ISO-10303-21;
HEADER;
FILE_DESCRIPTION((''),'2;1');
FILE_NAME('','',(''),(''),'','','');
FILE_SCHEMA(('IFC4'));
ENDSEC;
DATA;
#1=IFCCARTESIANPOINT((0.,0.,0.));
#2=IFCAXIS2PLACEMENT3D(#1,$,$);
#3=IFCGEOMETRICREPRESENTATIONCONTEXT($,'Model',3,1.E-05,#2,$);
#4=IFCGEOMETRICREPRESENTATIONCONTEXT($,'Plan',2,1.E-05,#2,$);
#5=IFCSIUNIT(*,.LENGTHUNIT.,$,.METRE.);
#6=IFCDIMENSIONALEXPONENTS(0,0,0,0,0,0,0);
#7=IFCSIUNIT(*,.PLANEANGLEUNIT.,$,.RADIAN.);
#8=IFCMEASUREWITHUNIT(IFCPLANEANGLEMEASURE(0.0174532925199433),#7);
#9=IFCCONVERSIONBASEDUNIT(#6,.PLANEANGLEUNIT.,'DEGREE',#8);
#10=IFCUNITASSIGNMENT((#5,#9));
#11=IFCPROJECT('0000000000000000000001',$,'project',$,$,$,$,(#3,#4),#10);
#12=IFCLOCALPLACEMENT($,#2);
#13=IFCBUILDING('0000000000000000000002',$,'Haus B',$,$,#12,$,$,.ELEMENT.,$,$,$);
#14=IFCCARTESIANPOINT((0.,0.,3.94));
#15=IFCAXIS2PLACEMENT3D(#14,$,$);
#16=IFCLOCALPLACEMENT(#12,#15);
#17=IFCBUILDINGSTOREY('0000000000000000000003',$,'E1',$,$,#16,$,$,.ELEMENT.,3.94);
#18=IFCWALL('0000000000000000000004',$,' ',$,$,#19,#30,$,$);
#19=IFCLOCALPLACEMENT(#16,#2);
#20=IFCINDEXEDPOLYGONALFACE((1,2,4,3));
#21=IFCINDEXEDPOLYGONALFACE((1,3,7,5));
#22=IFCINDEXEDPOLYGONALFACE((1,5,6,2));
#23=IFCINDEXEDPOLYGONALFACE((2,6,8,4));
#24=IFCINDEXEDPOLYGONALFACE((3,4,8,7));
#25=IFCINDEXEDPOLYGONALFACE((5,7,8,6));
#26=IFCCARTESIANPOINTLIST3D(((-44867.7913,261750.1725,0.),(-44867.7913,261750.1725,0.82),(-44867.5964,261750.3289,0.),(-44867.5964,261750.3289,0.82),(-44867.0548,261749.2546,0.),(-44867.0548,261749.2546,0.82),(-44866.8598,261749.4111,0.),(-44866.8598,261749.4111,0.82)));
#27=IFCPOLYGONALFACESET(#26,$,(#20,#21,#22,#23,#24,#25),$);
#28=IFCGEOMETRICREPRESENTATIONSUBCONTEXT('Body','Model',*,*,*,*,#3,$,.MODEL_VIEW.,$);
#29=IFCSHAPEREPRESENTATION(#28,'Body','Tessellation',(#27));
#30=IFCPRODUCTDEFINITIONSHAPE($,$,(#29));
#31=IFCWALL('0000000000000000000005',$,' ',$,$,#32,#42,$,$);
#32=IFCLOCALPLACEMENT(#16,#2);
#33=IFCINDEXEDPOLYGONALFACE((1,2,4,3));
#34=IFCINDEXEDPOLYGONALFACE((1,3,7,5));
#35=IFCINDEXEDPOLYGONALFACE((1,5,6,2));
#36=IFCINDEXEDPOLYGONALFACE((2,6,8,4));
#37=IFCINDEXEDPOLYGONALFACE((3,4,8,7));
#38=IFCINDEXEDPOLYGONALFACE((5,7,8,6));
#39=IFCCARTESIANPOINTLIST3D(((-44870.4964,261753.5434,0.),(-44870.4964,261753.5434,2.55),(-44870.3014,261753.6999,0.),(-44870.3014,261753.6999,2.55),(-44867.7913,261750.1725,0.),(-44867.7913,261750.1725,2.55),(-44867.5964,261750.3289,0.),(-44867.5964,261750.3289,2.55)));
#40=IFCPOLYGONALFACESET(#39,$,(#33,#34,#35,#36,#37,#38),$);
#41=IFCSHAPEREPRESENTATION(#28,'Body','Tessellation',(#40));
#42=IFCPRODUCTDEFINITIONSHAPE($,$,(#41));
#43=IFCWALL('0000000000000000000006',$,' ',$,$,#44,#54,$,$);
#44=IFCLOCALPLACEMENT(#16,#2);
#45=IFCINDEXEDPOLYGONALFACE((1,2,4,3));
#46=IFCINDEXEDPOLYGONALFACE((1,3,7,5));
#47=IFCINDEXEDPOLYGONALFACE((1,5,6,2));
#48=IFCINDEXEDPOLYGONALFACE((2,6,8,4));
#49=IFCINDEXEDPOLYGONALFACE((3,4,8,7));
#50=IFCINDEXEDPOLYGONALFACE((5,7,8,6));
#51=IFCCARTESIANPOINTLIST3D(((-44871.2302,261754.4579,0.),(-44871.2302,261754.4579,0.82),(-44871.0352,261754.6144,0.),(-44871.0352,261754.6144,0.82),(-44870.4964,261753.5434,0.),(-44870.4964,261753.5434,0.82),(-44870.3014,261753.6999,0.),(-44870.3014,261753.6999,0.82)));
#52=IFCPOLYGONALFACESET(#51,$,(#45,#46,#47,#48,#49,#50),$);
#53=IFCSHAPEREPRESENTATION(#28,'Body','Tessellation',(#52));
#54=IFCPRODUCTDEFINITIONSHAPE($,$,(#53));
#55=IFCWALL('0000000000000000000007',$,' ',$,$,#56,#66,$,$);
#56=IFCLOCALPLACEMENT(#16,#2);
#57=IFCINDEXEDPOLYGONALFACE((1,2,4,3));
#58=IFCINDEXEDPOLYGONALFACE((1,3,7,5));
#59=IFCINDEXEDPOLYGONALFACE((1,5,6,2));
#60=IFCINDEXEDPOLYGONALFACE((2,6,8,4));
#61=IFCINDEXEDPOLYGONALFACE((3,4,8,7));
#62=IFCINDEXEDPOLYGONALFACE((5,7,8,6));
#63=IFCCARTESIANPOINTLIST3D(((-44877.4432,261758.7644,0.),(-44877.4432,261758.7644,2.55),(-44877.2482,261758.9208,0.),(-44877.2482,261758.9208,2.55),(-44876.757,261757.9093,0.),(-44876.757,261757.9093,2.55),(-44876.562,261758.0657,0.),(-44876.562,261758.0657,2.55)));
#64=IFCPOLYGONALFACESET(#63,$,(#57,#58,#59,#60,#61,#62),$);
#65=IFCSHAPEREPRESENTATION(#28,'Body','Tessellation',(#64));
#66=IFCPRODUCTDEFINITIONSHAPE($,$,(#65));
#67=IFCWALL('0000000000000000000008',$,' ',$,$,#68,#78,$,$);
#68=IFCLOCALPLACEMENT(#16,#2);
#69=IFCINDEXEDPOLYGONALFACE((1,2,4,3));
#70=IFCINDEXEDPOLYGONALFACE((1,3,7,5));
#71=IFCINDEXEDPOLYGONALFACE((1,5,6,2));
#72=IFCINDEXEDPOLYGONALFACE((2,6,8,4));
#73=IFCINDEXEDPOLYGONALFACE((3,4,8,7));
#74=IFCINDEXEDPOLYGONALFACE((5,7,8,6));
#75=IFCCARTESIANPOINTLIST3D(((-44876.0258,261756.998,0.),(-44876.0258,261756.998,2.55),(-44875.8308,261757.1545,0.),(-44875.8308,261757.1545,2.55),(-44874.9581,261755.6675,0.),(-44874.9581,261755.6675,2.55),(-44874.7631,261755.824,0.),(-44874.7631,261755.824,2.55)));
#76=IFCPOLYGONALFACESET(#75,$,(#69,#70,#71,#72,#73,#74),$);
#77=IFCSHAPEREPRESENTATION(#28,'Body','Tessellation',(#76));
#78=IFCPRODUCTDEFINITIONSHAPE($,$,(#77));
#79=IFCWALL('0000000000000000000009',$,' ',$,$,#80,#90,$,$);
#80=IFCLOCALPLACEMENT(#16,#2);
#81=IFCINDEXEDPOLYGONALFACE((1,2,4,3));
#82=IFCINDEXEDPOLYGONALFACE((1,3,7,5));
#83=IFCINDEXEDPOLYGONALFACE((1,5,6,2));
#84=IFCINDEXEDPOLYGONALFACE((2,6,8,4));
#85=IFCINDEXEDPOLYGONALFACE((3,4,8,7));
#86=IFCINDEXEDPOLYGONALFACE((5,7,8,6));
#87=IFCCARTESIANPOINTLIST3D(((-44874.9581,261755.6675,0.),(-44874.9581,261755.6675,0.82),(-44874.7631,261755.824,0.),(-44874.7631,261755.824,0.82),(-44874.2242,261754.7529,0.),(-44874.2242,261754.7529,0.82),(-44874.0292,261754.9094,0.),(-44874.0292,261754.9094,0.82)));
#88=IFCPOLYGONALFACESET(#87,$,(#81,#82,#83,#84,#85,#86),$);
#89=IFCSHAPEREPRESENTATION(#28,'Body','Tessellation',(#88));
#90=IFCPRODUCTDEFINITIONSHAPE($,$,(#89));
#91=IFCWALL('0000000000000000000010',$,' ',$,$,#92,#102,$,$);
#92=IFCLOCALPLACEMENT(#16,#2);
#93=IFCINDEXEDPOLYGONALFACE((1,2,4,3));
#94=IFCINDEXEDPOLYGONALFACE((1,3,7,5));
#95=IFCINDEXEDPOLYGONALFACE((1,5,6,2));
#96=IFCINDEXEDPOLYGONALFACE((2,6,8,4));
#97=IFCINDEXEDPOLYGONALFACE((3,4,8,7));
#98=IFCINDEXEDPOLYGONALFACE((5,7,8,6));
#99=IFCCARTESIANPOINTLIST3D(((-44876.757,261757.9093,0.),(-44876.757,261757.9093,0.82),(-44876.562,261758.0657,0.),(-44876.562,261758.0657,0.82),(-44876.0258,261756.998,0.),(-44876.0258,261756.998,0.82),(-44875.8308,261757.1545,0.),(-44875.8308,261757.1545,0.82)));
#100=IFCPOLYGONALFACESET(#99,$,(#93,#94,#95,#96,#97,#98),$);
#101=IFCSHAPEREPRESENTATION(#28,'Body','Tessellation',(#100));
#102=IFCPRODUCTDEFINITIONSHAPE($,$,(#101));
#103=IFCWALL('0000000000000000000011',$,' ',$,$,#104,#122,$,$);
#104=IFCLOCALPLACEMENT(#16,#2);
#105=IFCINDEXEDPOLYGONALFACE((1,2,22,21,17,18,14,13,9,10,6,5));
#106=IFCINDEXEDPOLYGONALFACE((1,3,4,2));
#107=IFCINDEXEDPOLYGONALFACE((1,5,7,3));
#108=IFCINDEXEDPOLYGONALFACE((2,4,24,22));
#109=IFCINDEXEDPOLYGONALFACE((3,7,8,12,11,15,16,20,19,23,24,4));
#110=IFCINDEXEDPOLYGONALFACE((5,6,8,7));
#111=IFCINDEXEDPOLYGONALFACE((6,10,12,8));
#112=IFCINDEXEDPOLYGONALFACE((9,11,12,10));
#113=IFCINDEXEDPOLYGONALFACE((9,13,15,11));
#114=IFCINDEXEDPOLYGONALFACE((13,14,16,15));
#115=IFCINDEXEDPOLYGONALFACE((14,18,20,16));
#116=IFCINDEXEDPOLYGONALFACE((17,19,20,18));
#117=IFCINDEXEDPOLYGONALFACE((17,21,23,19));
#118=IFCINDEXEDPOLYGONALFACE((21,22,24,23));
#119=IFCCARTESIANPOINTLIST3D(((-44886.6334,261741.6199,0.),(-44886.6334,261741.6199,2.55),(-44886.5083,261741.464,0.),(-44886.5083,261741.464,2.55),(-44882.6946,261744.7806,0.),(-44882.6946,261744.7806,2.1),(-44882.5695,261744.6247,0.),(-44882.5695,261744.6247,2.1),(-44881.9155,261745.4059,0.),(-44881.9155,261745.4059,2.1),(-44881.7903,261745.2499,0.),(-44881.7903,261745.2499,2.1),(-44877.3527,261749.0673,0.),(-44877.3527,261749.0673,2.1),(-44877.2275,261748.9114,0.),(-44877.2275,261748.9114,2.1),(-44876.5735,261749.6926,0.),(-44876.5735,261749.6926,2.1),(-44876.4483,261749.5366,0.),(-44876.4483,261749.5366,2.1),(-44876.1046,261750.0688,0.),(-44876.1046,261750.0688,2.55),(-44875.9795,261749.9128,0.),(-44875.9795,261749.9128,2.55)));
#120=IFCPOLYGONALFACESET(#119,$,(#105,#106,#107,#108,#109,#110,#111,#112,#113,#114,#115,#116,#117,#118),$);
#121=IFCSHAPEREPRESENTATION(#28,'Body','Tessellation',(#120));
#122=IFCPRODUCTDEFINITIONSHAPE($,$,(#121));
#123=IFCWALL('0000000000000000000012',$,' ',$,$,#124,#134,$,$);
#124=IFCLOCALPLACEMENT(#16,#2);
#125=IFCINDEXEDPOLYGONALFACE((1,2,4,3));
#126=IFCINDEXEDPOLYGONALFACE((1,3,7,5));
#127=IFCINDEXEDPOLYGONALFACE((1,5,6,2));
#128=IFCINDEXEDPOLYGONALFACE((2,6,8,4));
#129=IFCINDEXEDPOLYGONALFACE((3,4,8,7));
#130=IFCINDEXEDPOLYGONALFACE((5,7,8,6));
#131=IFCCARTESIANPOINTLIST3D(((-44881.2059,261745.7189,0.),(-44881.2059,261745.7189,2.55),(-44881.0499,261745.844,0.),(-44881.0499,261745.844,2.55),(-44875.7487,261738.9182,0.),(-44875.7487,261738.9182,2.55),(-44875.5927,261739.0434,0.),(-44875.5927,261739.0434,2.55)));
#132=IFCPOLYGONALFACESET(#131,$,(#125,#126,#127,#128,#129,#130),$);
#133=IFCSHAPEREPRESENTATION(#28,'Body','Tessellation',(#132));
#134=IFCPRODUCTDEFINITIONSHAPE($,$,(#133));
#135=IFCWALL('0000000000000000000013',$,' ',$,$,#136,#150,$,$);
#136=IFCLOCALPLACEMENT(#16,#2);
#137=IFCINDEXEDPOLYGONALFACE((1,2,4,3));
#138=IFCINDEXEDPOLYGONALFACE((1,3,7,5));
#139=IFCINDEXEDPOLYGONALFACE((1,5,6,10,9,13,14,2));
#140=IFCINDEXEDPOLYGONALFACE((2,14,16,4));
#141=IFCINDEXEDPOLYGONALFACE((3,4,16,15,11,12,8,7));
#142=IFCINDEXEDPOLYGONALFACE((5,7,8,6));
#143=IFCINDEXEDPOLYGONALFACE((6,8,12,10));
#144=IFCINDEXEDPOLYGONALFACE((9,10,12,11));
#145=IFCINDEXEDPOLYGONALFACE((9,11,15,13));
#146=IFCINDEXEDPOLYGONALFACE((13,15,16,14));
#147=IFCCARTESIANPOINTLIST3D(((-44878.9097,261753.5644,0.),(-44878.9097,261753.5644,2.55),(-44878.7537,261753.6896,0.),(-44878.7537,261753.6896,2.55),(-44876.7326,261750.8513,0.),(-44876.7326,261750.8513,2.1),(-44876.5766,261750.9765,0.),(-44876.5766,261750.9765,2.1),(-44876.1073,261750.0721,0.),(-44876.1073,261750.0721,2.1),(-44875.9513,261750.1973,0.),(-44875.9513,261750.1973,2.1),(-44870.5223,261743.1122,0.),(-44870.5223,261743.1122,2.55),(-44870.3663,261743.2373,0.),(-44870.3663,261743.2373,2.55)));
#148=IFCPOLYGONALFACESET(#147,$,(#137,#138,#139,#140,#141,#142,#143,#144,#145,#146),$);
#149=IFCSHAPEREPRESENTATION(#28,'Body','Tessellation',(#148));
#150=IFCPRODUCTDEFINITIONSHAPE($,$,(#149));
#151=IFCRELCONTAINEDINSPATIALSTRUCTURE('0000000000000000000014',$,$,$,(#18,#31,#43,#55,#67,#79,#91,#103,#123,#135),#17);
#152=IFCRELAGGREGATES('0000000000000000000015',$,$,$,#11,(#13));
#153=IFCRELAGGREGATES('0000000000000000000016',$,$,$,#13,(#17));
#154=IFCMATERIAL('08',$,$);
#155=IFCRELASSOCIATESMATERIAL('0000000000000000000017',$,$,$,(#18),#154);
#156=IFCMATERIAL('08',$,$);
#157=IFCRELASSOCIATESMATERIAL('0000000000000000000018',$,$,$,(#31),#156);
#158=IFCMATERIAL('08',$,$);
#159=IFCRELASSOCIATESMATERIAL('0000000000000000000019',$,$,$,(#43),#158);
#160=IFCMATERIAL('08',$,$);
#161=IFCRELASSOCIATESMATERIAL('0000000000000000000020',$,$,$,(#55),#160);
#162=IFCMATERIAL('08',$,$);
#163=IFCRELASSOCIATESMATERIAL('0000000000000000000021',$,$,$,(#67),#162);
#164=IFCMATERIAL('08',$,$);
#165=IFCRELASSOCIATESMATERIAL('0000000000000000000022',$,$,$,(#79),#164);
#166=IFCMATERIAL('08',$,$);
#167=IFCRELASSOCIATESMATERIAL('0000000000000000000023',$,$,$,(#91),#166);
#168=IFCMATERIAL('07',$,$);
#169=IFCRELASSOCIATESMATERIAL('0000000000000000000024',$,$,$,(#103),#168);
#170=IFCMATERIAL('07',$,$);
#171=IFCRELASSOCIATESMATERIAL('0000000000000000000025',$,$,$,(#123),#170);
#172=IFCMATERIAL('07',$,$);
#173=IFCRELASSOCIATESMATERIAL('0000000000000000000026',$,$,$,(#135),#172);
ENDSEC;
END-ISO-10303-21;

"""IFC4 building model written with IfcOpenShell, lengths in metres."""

from ifc_helpers import new_model, entity, si_unit, converted_unit, frame, frame_2d, origin, origin_with_axes, place, context, subcontext, project, spatial, polyline, rectangle, outline, extrude, material, element, save


model = new_model("IFC4")

# Units and contexts
model_context = context("Model", 3, precision=1e-05, world=origin())
plan_context = context("Plan", 2, precision=1e-05, world=origin())
body_context = subcontext(model_context, "Body", "Model", "MODEL_VIEW")
ifc_project = project(units=[si_unit("LENGTHUNIT", "METRE"), converted_unit("PLANEANGLEUNIT", "DEGREE", entity("IfcPlaneAngleMeasure", 0.0174532925199433), si_unit("PLANEANGLEUNIT", "RADIAN"), dimensions=[0, 0, 0, 0, 0, 0, 0])], contexts=[model_context, plan_context])

# Building, storey
building_placement = place(None, origin())
building = spatial("IfcBuilding", under=ifc_project, at=building_placement, Name="Haus B", CompositionType="ELEMENT")
storey_placement = place(building_placement, frame((0.0, 0.0, 3.94)))
storey = spatial("IfcBuildingStorey", under=building, at=storey_placement, Name="E1", CompositionType="ELEMENT", Elevation=3.94)

# Walls
ifc_material_1 = material(Name="08")
wall_1_placement = place(storey_placement, frame((-44867.7913, 261750.1725, 0.0), z_axis=(0.0, 0.0, 1.0), x_axis=(0.625861, -0.779935, 0.0)))
element("IfcWall", 1, at=wall_1_placement, inside=storey, material=ifc_material_1, Name=" ", context=body_context, shape_type="SweptSolid", body=[
    extrude(rectangle(XDim=1.1768, YDim=0.25, at=frame_2d((0.5884, 0.125), x_axis=(1.0, 0.0))), origin_with_axes(), (0.0, 0.0, 1.0), 0.82),
])
ifc_material_2 = material(Name="08")
wall_2_placement = place(storey_placement, frame((-44870.4964, 261753.5434, 0.0), z_axis=(0.0, 0.0, 1.0), x_axis=(0.625861, -0.779935, 0.0)))
element("IfcWall", 2, at=wall_2_placement, inside=storey, material=ifc_material_2, Name=" ", context=body_context, shape_type="SweptSolid", body=[
    extrude(rectangle(XDim=4.3221, YDim=0.25, at=frame_2d((2.161, 0.125), x_axis=(1.0, 0.0))), origin_with_axes(), (0.0, 0.0, 1.0), 2.55),
])
ifc_material_3 = material(Name="08")
wall_3_placement = place(storey_placement, frame((-44871.2302, 261754.4579, 0.0), z_axis=(0.0, 0.0, 1.0), x_axis=(0.625861, -0.779935, 0.0)))
element("IfcWall", 3, at=wall_3_placement, inside=storey, material=ifc_material_3, Name=" ", context=body_context, shape_type="SweptSolid", body=[
    extrude(rectangle(XDim=1.1726, YDim=0.25, at=frame_2d((0.5863, 0.125), x_axis=(1.0, 0.0))), origin_with_axes(), (0.0, 0.0, 1.0), 0.82),
])
ifc_material_4 = material(Name="08")
wall_4_placement = place(storey_placement, frame((-44877.4432, 261758.7644, 0.0), z_axis=(0.0, 0.0, 1.0), x_axis=(0.625861, -0.779935, 0.0)))
element("IfcWall", 4, at=wall_4_placement, inside=storey, material=ifc_material_4, Name=" ", context=body_context, shape_type="SweptSolid", body=[
    extrude(rectangle(XDim=1.0964, YDim=0.25, at=frame_2d((0.5482, 0.125), x_axis=(1.0, 0.0))), origin_with_axes(), (0.0, 0.0, 1.0), 2.55),
])
ifc_material_5 = material(Name="08")
wall_5_placement = place(storey_placement, frame((-44876.0258, 261756.998, 0.0), z_axis=(0.0, 0.0, 1.0), x_axis=(0.625861, -0.779935, 0.0)))
element("IfcWall", 5, at=wall_5_placement, inside=storey, material=ifc_material_5, Name=" ", context=body_context, shape_type="SweptSolid", body=[
    extrude(rectangle(XDim=1.706, YDim=0.25, at=frame_2d((0.853, 0.125), x_axis=(1.0, 0.0))), origin_with_axes(), (0.0, 0.0, 1.0), 2.55),
])
ifc_material_6 = material(Name="08")
wall_6_placement = place(storey_placement, frame((-44874.9581, 261755.6675, 0.0), z_axis=(0.0, 0.0, 1.0), x_axis=(0.625861, -0.779935, 0.0)))
element("IfcWall", 6, at=wall_6_placement, inside=storey, material=ifc_material_6, Name=" ", context=body_context, shape_type="SweptSolid", body=[
    extrude(rectangle(XDim=1.1726, YDim=0.25, at=frame_2d((0.5863, 0.125), x_axis=(1.0, 0.0))), origin_with_axes(), (0.0, 0.0, 1.0), 0.82),
])
ifc_material_7 = material(Name="08")
wall_7_placement = place(storey_placement, frame((-44876.757, 261757.9093, 0.0), z_axis=(0.0, 0.0, 1.0), x_axis=(0.625861, -0.779935, 0.0)))
element("IfcWall", 7, at=wall_7_placement, inside=storey, material=ifc_material_7, Name=" ", context=body_context, shape_type="SweptSolid", body=[
    extrude(rectangle(XDim=1.1684, YDim=0.25, at=frame_2d((0.5842, 0.125), x_axis=(1.0, 0.0))), origin_with_axes(), (0.0, 0.0, 1.0), 0.82),
])

# Wall, openings
ifc_material_8 = material(Name="07")
wall_8_placement = place(storey_placement, frame((-44876.1046, 261750.0688, 0.0), z_axis=(0.0, 0.0, 1.0), x_axis=(-0.779935, -0.625861, 0.0)))
wall_8 = element("IfcWall", 8, at=wall_8_placement, inside=storey, material=ifc_material_8, Name=" ", context=body_context, shape_type="SweptSolid", body=[
    extrude(rectangle(XDim=13.4996, YDim=0.2, at=frame_2d((6.7498, 0.1), x_axis=(1.0, 0.0))), origin_with_axes(), (0.0, 0.0, 1.0), 2.55),
])
opening_1_placement = place(wall_8_placement, frame((8.4494, 0.2, 0.0), z_axis=(0.0, -1.0, 0.0), x_axis=(0.0, 0.0, 1.0)))
element("IfcOpeningElement", 9, at=opening_1_placement, cuts=wall_8, ObjectType="Opening", context=body_context, shape_type="SweptSolid", body=[
    extrude(outline(polyline([(0.0, 0.999), (0.0, 0.0), (2.1, 0.0), (2.1, 0.999), (0.0, 0.999)])), origin_with_axes(), (0.0, 0.0, 1.0), 0.2),
])
opening_2_placement = place(wall_8_placement, frame((1.6001, 0.2, 0.0), z_axis=(0.0, -1.0, 0.0), x_axis=(0.0, 0.0, 1.0)))
element("IfcOpeningElement", 10, at=opening_2_placement, cuts=wall_8, ObjectType="Opening", context=body_context, shape_type="SweptSolid", body=[
    extrude(outline(polyline([(0.0, 0.999), (0.0, 0.0), (2.1, 0.0), (2.1, 0.999), (0.0, 0.999)])), origin_with_axes(), (0.0, 0.0, 1.0), 0.2),
])

# Wall
ifc_material_9 = material(Name="07")
wall_9_placement = place(storey_placement, frame((-44881.2059, 261745.7189, 0.0), z_axis=(0.0, 0.0, 1.0), x_axis=(0.625861, -0.779935, 0.0)))
element("IfcWall", 11, at=wall_9_placement, inside=storey, material=ifc_material_9, Name=" ", context=body_context, shape_type="SweptSolid", body=[
    extrude(rectangle(XDim=8.7195, YDim=0.2, at=frame_2d((4.3598, 0.1), x_axis=(1.0, 0.0))), origin_with_axes(), (0.0, 0.0, 1.0), 2.55),
])

# Wall, opening
ifc_material_10 = material(Name="07")
wall_10_placement = place(storey_placement, frame((-44878.9097, 261753.5644, 0.0), z_axis=(0.0, 0.0, 1.0), x_axis=(0.625861, -0.779935, 0.0)))
wall_10 = element("IfcWall", 12, at=wall_10_placement, inside=storey, material=ifc_material_10, Name=" ", context=body_context, shape_type="SweptSolid", body=[
    extrude(rectangle(XDim=13.4014, YDim=0.2, at=frame_2d((6.7007, 0.1), x_axis=(1.0, 0.0))), origin_with_axes(), (0.0, 0.0, 1.0), 2.55),
])
opening_3_placement = place(wall_10_placement, frame((4.4777, 0.2, 0.0), z_axis=(0.0, -1.0, 0.0), x_axis=(0.0, 0.0, 1.0)))
element("IfcOpeningElement", 13, at=opening_3_placement, cuts=wall_10, ObjectType="Opening", context=body_context, shape_type="SweptSolid", body=[
    extrude(outline(polyline([(0.0, 0.999), (2.1, 0.999), (2.1, 0.0), (0.0, 0.0), (0.0, 0.999)])), origin_with_axes(), (0.0, 0.0, 1.0), 0.2),
])

save(model, "model.ifc")
